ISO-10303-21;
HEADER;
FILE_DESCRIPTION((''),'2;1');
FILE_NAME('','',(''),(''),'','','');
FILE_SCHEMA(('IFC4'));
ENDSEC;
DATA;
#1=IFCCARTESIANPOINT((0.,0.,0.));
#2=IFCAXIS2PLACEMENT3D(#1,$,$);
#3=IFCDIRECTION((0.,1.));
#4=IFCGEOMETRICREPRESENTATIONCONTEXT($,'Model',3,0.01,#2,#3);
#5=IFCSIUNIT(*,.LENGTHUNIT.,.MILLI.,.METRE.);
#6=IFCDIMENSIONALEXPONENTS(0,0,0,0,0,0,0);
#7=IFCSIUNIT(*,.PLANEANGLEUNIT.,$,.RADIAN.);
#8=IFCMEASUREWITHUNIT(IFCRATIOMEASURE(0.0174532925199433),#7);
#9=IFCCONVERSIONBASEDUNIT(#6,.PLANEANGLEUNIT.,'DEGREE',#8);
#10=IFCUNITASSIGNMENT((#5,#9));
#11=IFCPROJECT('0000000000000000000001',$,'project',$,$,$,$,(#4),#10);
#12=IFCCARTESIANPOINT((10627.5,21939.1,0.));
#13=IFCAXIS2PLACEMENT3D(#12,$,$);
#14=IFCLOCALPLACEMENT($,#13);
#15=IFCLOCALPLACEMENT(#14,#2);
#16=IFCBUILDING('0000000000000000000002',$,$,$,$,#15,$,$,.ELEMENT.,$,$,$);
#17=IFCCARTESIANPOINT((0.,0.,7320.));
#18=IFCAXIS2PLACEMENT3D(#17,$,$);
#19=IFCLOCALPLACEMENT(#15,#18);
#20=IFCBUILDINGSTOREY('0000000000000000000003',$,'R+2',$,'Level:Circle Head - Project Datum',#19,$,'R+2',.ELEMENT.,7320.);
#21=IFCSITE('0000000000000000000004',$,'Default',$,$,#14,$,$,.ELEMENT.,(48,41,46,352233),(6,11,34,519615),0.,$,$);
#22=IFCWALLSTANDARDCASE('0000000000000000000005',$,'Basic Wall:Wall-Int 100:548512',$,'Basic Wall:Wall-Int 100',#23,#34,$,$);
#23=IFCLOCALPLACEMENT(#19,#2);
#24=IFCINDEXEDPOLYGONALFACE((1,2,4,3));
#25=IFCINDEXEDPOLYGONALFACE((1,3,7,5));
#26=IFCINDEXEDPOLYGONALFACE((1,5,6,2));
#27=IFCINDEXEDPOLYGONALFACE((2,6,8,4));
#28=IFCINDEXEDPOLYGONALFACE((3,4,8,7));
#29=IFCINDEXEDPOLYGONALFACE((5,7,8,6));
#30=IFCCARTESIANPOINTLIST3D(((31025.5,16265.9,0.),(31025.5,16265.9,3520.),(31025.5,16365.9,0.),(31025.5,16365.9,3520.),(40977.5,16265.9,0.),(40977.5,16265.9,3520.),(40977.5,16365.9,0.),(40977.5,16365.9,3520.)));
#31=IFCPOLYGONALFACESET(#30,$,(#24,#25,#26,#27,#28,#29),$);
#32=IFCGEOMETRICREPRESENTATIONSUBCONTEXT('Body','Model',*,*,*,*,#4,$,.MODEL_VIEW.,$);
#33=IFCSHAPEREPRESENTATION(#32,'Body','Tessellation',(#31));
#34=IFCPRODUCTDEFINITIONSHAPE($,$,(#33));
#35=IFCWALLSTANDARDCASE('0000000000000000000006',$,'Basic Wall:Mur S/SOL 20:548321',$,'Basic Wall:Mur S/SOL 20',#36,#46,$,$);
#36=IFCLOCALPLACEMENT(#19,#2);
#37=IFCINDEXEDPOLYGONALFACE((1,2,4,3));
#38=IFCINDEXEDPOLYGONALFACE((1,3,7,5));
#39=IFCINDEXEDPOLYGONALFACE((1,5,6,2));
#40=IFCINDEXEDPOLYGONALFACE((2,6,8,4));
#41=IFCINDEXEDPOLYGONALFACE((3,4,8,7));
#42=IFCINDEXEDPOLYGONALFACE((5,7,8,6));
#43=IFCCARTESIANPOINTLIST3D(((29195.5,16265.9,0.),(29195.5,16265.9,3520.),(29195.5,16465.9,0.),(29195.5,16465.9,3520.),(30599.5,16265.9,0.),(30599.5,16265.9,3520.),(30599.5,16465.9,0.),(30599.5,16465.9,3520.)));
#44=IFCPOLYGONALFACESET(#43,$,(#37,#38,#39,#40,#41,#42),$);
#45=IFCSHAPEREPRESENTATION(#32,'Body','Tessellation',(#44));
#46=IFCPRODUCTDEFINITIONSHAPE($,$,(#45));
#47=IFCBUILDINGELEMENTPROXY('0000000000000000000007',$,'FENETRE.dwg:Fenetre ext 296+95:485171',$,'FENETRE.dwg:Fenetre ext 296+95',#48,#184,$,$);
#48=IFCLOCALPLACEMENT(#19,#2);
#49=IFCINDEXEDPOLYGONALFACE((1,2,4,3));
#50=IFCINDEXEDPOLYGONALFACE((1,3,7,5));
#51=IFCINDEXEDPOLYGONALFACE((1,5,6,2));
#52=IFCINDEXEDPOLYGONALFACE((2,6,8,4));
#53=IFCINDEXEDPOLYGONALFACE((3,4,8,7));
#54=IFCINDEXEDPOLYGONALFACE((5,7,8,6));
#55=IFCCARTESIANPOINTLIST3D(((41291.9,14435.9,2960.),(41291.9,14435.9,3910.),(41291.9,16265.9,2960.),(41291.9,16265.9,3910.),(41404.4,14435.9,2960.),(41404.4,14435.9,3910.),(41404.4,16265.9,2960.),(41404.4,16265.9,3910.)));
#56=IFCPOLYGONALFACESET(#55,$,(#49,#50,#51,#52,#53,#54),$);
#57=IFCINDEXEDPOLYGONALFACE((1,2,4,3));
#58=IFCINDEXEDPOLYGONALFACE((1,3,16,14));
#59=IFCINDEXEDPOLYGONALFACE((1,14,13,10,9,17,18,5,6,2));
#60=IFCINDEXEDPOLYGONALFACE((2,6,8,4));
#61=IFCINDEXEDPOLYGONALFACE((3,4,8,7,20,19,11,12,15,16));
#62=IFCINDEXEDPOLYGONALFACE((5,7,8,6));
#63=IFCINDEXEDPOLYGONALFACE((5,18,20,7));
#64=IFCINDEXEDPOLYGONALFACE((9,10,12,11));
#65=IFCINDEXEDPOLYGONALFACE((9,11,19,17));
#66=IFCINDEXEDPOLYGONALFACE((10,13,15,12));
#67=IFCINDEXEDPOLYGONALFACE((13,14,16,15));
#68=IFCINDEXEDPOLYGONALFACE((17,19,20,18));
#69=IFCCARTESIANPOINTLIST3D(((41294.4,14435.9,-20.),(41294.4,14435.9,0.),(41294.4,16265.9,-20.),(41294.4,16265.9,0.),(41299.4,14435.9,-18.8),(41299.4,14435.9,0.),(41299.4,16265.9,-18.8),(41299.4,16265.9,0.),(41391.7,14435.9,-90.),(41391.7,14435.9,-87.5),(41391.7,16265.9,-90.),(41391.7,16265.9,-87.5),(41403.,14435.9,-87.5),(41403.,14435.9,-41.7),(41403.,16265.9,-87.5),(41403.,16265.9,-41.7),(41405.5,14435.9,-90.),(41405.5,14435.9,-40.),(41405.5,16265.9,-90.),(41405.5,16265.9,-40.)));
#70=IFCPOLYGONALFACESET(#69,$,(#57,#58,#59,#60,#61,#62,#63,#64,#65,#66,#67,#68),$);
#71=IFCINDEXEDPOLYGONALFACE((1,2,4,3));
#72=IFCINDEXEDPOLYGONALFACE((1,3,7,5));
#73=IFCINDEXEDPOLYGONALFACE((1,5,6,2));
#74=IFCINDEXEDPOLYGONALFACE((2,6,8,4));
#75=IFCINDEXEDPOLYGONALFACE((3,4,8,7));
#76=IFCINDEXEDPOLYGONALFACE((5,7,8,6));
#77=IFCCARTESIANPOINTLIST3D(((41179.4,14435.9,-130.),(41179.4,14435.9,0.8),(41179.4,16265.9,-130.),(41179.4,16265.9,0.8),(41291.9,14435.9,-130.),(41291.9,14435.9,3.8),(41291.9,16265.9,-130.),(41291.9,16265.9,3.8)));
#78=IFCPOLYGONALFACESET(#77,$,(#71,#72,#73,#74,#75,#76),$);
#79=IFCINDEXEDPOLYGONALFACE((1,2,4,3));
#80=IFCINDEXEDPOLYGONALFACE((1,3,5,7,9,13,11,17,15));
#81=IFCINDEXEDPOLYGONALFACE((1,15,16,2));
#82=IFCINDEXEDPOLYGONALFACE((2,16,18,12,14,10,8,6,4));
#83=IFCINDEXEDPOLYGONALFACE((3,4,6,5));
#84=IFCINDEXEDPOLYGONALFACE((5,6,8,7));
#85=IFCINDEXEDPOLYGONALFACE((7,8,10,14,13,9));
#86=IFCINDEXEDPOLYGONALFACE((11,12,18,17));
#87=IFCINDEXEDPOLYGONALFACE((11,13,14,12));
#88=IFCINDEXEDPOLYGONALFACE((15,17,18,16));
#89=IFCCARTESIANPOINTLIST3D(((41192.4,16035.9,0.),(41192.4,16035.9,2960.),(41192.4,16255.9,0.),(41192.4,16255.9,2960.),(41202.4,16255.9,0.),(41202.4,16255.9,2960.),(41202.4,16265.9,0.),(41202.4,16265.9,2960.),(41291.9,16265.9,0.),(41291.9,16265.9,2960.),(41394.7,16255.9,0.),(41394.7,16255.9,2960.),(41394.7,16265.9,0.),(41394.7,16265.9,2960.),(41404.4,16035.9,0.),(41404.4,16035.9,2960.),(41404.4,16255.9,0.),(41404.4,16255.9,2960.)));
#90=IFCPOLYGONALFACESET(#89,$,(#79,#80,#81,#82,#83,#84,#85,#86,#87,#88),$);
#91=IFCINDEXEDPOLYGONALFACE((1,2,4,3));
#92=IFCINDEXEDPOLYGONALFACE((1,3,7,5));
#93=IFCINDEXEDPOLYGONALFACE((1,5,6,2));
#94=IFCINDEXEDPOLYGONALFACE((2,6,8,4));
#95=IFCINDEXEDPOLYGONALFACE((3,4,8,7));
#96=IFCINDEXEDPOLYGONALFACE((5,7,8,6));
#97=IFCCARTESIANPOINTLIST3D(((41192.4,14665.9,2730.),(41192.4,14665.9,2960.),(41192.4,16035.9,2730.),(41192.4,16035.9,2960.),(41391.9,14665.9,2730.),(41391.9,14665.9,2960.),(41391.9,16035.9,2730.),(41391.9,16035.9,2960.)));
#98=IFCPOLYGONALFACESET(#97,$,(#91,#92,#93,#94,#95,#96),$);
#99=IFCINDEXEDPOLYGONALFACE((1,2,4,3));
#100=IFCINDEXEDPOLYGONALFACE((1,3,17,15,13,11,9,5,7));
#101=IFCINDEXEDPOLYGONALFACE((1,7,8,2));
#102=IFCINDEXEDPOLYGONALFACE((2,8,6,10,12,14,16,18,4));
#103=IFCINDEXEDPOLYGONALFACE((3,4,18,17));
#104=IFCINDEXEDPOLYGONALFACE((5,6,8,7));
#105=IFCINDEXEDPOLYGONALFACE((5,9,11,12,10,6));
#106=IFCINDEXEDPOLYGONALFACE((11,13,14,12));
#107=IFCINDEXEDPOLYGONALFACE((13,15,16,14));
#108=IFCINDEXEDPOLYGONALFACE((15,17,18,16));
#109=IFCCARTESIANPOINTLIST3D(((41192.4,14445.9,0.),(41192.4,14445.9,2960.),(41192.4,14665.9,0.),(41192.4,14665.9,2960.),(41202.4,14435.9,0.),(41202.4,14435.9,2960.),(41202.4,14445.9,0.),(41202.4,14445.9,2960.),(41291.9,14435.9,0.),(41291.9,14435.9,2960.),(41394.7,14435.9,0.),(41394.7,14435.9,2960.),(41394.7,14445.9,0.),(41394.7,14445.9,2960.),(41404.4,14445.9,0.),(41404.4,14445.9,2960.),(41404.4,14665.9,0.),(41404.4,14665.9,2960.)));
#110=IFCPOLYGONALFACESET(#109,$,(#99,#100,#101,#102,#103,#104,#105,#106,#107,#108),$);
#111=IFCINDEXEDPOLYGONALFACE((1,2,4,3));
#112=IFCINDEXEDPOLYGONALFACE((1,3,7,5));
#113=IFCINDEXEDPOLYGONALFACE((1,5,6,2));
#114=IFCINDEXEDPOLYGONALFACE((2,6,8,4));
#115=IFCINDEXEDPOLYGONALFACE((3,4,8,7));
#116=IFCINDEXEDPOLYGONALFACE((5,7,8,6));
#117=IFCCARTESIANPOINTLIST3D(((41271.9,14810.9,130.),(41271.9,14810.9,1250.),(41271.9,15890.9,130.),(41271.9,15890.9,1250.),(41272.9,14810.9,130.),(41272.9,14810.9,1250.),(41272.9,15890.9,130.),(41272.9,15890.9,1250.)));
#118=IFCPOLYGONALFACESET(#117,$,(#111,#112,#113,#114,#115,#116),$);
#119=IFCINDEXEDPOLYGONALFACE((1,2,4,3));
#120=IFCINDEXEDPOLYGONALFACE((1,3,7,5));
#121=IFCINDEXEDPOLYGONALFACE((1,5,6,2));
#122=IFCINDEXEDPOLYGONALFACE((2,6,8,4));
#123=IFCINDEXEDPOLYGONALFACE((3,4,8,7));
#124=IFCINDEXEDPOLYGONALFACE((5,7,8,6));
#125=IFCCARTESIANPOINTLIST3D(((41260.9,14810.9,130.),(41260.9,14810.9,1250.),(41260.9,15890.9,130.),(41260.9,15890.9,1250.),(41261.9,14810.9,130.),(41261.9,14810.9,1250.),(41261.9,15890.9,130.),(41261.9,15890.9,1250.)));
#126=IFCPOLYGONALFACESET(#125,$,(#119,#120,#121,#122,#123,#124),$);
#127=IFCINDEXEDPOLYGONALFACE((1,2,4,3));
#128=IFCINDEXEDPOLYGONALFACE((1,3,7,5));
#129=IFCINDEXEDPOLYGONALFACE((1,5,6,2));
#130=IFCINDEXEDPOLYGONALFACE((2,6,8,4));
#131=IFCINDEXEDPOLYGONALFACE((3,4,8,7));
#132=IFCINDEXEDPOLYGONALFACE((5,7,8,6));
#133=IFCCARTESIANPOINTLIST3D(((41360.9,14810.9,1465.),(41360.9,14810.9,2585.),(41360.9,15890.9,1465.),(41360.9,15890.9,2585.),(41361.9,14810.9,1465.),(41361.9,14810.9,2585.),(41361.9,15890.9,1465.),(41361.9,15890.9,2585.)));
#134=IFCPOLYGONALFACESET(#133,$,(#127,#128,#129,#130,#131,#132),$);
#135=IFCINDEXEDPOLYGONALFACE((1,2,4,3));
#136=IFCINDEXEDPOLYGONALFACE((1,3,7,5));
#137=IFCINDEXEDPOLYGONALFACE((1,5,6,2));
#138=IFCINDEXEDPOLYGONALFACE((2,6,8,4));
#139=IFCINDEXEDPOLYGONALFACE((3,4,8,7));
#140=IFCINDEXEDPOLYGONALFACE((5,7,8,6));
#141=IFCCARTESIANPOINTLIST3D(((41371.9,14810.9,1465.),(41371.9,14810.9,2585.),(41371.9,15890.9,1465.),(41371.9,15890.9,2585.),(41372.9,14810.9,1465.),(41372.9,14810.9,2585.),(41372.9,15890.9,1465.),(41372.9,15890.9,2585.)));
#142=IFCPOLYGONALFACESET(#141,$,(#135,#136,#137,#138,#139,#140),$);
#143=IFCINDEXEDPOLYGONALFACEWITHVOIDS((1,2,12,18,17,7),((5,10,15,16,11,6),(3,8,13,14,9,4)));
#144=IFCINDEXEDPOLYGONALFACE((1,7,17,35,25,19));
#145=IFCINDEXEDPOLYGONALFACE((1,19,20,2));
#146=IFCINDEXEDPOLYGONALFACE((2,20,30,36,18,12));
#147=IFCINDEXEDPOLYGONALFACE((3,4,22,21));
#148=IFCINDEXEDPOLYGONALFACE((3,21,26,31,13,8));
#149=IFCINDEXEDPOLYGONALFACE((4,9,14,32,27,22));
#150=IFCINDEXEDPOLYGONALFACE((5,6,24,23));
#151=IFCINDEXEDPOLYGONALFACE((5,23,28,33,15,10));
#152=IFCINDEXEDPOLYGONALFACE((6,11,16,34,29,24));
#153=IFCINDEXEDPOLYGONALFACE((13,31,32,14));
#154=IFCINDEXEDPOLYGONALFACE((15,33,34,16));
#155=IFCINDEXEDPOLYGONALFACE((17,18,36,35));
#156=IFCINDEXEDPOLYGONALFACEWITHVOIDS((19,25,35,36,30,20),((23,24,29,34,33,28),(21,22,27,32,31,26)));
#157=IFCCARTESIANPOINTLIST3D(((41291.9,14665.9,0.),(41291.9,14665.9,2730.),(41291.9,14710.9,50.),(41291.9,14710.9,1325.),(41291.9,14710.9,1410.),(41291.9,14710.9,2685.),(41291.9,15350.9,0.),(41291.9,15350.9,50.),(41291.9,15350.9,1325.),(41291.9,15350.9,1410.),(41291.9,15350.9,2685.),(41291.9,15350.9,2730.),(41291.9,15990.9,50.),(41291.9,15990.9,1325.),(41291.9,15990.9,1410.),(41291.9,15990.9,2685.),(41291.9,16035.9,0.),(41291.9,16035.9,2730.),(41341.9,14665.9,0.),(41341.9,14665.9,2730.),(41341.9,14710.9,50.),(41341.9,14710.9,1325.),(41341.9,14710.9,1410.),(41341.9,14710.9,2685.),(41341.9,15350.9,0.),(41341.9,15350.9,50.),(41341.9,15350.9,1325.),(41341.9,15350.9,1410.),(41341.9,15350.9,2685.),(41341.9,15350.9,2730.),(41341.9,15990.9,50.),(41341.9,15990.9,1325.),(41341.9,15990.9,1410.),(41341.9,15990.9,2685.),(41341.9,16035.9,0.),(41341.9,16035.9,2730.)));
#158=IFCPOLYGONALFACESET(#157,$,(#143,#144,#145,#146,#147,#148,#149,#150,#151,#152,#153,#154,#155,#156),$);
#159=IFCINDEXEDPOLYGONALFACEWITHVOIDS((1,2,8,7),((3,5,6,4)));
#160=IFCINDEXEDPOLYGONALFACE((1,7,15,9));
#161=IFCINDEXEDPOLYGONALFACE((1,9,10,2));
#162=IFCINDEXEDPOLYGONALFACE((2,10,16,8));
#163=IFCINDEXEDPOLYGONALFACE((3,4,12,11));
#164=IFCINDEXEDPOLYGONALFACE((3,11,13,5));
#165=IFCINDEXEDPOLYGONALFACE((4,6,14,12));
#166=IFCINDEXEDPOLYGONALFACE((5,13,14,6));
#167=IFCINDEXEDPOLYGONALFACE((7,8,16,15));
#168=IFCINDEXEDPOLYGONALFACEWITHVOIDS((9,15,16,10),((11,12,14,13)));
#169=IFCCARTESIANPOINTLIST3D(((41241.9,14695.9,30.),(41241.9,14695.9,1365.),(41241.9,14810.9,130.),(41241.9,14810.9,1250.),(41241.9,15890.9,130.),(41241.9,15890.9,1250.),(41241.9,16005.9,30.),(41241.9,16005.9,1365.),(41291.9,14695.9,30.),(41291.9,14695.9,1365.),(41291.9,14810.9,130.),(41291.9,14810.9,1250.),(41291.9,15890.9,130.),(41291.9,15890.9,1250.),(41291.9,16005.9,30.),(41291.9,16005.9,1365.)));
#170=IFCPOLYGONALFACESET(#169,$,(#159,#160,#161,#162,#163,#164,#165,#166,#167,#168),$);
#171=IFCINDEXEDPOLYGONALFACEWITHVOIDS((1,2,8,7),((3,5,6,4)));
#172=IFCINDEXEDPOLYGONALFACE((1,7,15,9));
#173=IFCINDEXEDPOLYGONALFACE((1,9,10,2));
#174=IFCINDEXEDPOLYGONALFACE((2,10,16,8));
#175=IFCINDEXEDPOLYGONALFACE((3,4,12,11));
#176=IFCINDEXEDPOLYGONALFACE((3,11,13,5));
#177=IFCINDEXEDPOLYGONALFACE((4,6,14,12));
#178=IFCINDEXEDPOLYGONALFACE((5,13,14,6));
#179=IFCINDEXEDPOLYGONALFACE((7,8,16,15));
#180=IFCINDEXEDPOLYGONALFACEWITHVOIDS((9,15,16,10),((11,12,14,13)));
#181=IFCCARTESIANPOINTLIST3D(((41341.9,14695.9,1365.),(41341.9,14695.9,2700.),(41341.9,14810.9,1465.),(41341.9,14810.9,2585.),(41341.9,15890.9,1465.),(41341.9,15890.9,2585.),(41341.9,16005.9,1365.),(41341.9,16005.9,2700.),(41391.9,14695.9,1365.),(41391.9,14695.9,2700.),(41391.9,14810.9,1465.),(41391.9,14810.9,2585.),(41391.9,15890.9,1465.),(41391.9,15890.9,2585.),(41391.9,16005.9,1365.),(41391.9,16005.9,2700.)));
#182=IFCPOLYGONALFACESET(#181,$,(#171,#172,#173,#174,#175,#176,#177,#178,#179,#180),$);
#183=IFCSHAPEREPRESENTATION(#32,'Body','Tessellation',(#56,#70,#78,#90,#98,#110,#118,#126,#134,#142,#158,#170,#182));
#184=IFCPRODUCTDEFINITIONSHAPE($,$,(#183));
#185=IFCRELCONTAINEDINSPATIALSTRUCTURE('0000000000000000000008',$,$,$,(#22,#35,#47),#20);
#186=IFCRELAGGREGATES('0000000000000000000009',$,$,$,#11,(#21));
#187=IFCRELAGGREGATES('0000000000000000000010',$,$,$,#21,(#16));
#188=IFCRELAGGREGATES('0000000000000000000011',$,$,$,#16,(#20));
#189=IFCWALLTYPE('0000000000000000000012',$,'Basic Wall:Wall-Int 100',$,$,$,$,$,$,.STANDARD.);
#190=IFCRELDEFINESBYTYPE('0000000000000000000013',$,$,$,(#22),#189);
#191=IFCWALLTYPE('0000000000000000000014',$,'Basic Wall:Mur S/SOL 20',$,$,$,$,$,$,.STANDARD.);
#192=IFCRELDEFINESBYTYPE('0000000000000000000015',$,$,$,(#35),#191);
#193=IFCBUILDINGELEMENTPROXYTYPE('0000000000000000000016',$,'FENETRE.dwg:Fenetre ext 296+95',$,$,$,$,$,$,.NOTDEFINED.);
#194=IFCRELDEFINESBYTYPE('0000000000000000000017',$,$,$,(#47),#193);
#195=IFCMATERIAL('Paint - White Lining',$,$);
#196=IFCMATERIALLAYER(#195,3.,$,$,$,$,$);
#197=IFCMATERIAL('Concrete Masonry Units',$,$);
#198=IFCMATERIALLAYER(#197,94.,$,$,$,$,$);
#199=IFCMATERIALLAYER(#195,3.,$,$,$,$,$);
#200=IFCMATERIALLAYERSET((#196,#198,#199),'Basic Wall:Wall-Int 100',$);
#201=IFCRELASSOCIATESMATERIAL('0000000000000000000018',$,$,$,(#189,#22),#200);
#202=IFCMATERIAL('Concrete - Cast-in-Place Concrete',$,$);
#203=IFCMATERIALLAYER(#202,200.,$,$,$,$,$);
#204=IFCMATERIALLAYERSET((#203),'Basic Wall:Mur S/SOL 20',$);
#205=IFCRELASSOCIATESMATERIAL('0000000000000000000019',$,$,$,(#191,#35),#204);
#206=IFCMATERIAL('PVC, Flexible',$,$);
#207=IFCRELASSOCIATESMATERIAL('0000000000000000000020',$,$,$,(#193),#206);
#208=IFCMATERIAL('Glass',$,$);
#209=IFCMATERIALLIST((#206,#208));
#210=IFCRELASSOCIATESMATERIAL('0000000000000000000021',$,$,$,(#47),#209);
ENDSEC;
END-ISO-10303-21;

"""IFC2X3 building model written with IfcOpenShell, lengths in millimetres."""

from ifc_helpers import new_model, entity, si_unit, converted_unit, direction, frame, frame_2d, origin, origin_2d_with_axis, place, context, subcontext, project, spatial, polyline, rectangle, outline, extrude, source, transform, mapped, material, material_list, layer, layer_set, layer_usage, type_object, type_shapes, element, save


model = new_model("IFC2X3")

# Units and contexts
model_context = context("Model", 3, precision=0.01, world=origin(), true_north=direction((0.0, 1.0)))
body_context = subcontext(model_context, "Body", "Model", "MODEL_VIEW")
ifc_project = project(units=[si_unit("LENGTHUNIT", "METRE", prefix="MILLI"), converted_unit("PLANEANGLEUNIT", "DEGREE", entity("IfcRatioMeasure", 0.0174532925199433), si_unit("PLANEANGLEUNIT", "RADIAN"), dimensions=[0, 0, 0, 0, 0, 0, 0])], contexts=[model_context])

# Site, building, storey
site_placement = place(None, frame((10627.5, 21939.1, 0.0)))
site = spatial("IfcSite", under=ifc_project, at=site_placement, Name="Default", CompositionType="ELEMENT", RefLatitude=(48, 41, 46, 352233), RefLongitude=(6, 11, 34, 519615), RefElevation=0.0)
building_placement = place(site_placement, origin())
building = spatial("IfcBuilding", under=site, at=building_placement, CompositionType="ELEMENT")
storey_placement = place(building_placement, frame((0.0, 0.0, 7320.0)))
storey = spatial("IfcBuildingStorey", under=building, at=storey_placement, Name="R+2", ObjectType="Level:Circle Head - Project Datum", LongName="R+2", CompositionType="ELEMENT", Elevation=7320.0)

# Walls
ifc_material_1 = material(Name="Paint - White Lining")
ifc_layer_1 = layer(ifc_material_1, 3.0)
ifc_material_2 = material(Name="Concrete Masonry Units")
ifc_layer_2 = layer(ifc_material_2, 94.0)
ifc_layer_3 = layer(ifc_material_1, 3.0)
ifc_layer_set_1 = layer_set([ifc_layer_1, ifc_layer_2, ifc_layer_3], Name="Basic Wall:Wall-Int 100")
ifc_layer_usage_1 = layer_usage(ifc_layer_set_1, "AXIS2", "POSITIVE", -50.0)
wall_type_1 = type_object("IfcWallType", Name="Basic Wall:Wall-Int 100", PredefinedType="STANDARD", material=ifc_layer_set_1)
wall_1_placement = place(storey_placement, frame((31025.5, 16315.9, 0.0)))
element("IfcWallStandardCase", 1, at=wall_1_placement, inside=storey, type_object=wall_type_1, material=ifc_layer_usage_1, Name="Basic Wall:Wall-Int 100:548512", ObjectType="Basic Wall:Wall-Int 100", context=body_context, shape_type="SweptSolid", body=[
    extrude(rectangle(XDim=9952.0, YDim=100.0, at=frame_2d((4976.0, 0.0), x_axis=(-1.0, 0.0))), origin(), (0.0, 0.0, 1.0), 3520.0),
])
ifc_material_3 = material(Name="Concrete - Cast-in-Place Concrete")
ifc_layer_4 = layer(ifc_material_3, 200.0)
ifc_layer_set_2 = layer_set([ifc_layer_4], Name="Basic Wall:Mur S/SOL 20")
ifc_layer_usage_2 = layer_usage(ifc_layer_set_2, "AXIS2", "POSITIVE", -100.0)
wall_type_2 = type_object("IfcWallType", Name="Basic Wall:Mur S/SOL 20", PredefinedType="STANDARD", material=ifc_layer_set_2)
wall_2_placement = place(storey_placement, frame((29195.5, 16365.9, 0.0)))
element("IfcWallStandardCase", 2, at=wall_2_placement, inside=storey, type_object=wall_type_2, material=ifc_layer_usage_2, Name="Basic Wall:Mur S/SOL 20:548321", ObjectType="Basic Wall:Mur S/SOL 20", context=body_context, shape_type="SweptSolid", body=[
    extrude(rectangle(XDim=1404.0, YDim=200.0, at=frame_2d((702.0, 0.0), x_axis=(-1.0, 0.0))), origin(), (0.0, 0.0, 1.0), 3520.0),
])

# Building element proxy
ifc_material_4 = material(Name="PVC, Flexible")
ifc_material_5 = material(Name="Glass")
ifc_material_list_1 = material_list([ifc_material_4, ifc_material_5])
building_element_proxy_type_1 = type_object("IfcBuildingElementProxyType", Name="FENETRE.dwg:Fenetre ext 296+95", PredefinedType="NOTDEFINED", material=ifc_material_4)
shared_shape_1 = source(origin(), body_context, "Body", "SweptSolid", [
    extrude(rectangle(XDim=112.5, YDim=1830.0, at=origin_2d_with_axis()), frame((-10.4, -56.3, 2960.0), z_axis=(0.0, 0.0, 1.0), x_axis=(0.0, 1.0, 0.0)), (0.0, 0.0, 1.0), 950.0),
    extrude(outline(polyline([(27.5, -64.4), (47.5, -64.4), (47.5, -59.4), (28.8, -59.4), (7.5, 46.7), (-42.5, 46.7), (-42.5, 32.9), (-40.0, 32.9), (-40.0, 44.2), (5.8, 44.2), (27.5, -64.4)])), frame((-925.4, -66.9, -47.5), z_axis=(1.0, 0.0, 0.0), x_axis=(0.0, 0.0, 1.0)), (0.0, 0.0, 1.0), 1830.0),
    extrude(outline(polyline([(-54.5, -66.1), (58.0, -66.1), (54.5, 67.6), (-58.0, 64.6), (-54.5, -66.1)])), frame((-925.4, 56.3, -63.8), z_axis=(1.0, 0.0, 0.0), x_axis=(0.0, -0.999645, 0.02665)), (0.0, 0.0, 1.0), 1830.0),
    extrude(outline(polyline([(-97.0, -55.6), (5.9, -55.6), (95.4, -55.6), (95.4, -45.6), (105.4, -45.6), (105.4, 174.4), (-106.6, 174.4), (-106.6, -45.6), (-97.0, -45.6), (-97.0, -55.6)])), frame((849.0, -5.9, 0.0), z_axis=(0.0, 0.0, 1.0), x_axis=(0.0, 1.0, 0.0)), (0.0, 0.0, 1.0), 2960.0),
    extrude(rectangle(XDim=1370.0, YDim=199.5, at=origin_2d_with_axis()), frame((-10.4, -0.3, 2730.0), z_axis=(0.0, 0.0, 1.0), x_axis=(-1.0, 0.0, 0.0)), (0.0, 0.0, 1.0), 230.0),
    extrude(outline(polyline([(-55.6, 97.0), (-55.6, -5.9), (-55.6, -95.4), (-45.6, -95.4), (-45.6, -105.4), (174.4, -105.4), (174.4, 106.6), (-45.6, 106.6), (-45.6, 97.0), (-55.6, 97.0)])), frame((-869.9, -5.9, 0.0), z_axis=(0.0, 0.0, -1.0), x_axis=(1.0, 0.0, 0.0)), (0.0, 0.0, -1.0), 2960.0),
    extrude(rectangle(XDim=1080.0, YDim=1.0, at=origin_2d_with_axis()), frame((-10.4, 19.5, 130.0), z_axis=(0.0, 0.0, 1.0), x_axis=(-1.0, 0.0, 0.0)), (0.0, 0.0, 1.0), 1120.0),
    extrude(rectangle(XDim=1080.0, YDim=1.0, at=origin_2d_with_axis()), frame((-10.4, 30.5, 130.0), z_axis=(0.0, 0.0, 1.0), x_axis=(-1.0, 0.0, 0.0)), (0.0, 0.0, 1.0), 1120.0),
    extrude(rectangle(XDim=1080.0, YDim=1.0, at=frame_2d((0.0, 0.0), x_axis=(1.0, 0.0))), frame((-10.4, -69.5, 1465.0), z_axis=(0.0, 0.0, 1.0), x_axis=(-1.0, 0.0, 0.0)), (0.0, 0.0, 1.0), 1120.0),
    extrude(rectangle(XDim=1080.0, YDim=1.0, at=frame_2d((0.0, 0.0), x_axis=(1.0, 0.0))), frame((-10.4, -80.5, 1465.0), z_axis=(0.0, 0.0, 1.0), x_axis=(-1.0, 0.0, 0.0)), (0.0, 0.0, 1.0), 1120.0),
    extrude(outline(polyline([(-685.0, -1365.0), (0.0, -1365.0), (685.0, -1365.0), (685.0, 1365.0), (0.0, 1365.0), (-685.0, 1365.0), (-685.0, -1365.0)]), holes=[polyline([(-640.0, -1320.0), (-640.0, -45.0), (0.0, -45.0), (640.0, -45.0), (640.0, -1320.0), (0.0, -1320.0), (-640.0, -1320.0)]), polyline([(-640.0, 40.0), (-640.0, 1315.0), (0.0, 1315.0), (640.0, 1315.0), (640.0, 40.0), (0.0, 40.0), (-640.0, 40.0)])]), frame((-10.4, -50.0, 1365.0), z_axis=(0.0, 1.0, 0.0), x_axis=(1.0, 0.0, 0.0)), (0.0, 0.0, 1.0), 50.0),
    extrude(outline(polyline([(-655.0, -667.5), (655.0, -667.5), (655.0, 667.5), (-655.0, 667.5), (-655.0, -667.5)]), holes=[polyline([(-540.0, 552.5), (540.0, 552.5), (540.0, -567.5), (-540.0, -567.5), (-540.0, 552.5)])]), frame((-10.4, 0.0, 697.5), z_axis=(0.0, 1.0, 0.0), x_axis=(-1.0, 0.0, 0.0)), (0.0, 0.0, 1.0), 50.0),
    extrude(outline(polyline([(-655.0, -667.5), (655.0, -667.5), (655.0, 667.5), (-655.0, 667.5), (-655.0, -667.5)]), holes=[polyline([(-540.0, 552.5), (540.0, 552.5), (540.0, -567.5), (-540.0, -567.5), (-540.0, 552.5)])]), frame((-10.4, -100.0, 2032.5), z_axis=(0.0, 1.0, 0.0), x_axis=(-1.0, 0.0, 0.0)), (0.0, 0.0, 1.0), 50.0),
])
type_shapes(building_element_proxy_type_1, [shared_shape_1])
proxy_1_placement = place(storey_placement, frame((41291.9, 15361.3, 0.0), z_axis=(0.0, 0.0, 1.0), x_axis=(0.0, 1.0, 0.0)))
element("IfcBuildingElementProxy", 3, at=proxy_1_placement, inside=storey, type_object=building_element_proxy_type_1, material=ifc_material_list_1, Name="FENETRE.dwg:Fenetre ext 296+95:485171", ObjectType="FENETRE.dwg:Fenetre ext 296+95", context=body_context, shape_type="MappedRepresentation", body=[
    mapped(shared_shape_1, transform((0.0, 0.0, 0.0), scale=1.0)),
])

save(model, "model.ifc")
